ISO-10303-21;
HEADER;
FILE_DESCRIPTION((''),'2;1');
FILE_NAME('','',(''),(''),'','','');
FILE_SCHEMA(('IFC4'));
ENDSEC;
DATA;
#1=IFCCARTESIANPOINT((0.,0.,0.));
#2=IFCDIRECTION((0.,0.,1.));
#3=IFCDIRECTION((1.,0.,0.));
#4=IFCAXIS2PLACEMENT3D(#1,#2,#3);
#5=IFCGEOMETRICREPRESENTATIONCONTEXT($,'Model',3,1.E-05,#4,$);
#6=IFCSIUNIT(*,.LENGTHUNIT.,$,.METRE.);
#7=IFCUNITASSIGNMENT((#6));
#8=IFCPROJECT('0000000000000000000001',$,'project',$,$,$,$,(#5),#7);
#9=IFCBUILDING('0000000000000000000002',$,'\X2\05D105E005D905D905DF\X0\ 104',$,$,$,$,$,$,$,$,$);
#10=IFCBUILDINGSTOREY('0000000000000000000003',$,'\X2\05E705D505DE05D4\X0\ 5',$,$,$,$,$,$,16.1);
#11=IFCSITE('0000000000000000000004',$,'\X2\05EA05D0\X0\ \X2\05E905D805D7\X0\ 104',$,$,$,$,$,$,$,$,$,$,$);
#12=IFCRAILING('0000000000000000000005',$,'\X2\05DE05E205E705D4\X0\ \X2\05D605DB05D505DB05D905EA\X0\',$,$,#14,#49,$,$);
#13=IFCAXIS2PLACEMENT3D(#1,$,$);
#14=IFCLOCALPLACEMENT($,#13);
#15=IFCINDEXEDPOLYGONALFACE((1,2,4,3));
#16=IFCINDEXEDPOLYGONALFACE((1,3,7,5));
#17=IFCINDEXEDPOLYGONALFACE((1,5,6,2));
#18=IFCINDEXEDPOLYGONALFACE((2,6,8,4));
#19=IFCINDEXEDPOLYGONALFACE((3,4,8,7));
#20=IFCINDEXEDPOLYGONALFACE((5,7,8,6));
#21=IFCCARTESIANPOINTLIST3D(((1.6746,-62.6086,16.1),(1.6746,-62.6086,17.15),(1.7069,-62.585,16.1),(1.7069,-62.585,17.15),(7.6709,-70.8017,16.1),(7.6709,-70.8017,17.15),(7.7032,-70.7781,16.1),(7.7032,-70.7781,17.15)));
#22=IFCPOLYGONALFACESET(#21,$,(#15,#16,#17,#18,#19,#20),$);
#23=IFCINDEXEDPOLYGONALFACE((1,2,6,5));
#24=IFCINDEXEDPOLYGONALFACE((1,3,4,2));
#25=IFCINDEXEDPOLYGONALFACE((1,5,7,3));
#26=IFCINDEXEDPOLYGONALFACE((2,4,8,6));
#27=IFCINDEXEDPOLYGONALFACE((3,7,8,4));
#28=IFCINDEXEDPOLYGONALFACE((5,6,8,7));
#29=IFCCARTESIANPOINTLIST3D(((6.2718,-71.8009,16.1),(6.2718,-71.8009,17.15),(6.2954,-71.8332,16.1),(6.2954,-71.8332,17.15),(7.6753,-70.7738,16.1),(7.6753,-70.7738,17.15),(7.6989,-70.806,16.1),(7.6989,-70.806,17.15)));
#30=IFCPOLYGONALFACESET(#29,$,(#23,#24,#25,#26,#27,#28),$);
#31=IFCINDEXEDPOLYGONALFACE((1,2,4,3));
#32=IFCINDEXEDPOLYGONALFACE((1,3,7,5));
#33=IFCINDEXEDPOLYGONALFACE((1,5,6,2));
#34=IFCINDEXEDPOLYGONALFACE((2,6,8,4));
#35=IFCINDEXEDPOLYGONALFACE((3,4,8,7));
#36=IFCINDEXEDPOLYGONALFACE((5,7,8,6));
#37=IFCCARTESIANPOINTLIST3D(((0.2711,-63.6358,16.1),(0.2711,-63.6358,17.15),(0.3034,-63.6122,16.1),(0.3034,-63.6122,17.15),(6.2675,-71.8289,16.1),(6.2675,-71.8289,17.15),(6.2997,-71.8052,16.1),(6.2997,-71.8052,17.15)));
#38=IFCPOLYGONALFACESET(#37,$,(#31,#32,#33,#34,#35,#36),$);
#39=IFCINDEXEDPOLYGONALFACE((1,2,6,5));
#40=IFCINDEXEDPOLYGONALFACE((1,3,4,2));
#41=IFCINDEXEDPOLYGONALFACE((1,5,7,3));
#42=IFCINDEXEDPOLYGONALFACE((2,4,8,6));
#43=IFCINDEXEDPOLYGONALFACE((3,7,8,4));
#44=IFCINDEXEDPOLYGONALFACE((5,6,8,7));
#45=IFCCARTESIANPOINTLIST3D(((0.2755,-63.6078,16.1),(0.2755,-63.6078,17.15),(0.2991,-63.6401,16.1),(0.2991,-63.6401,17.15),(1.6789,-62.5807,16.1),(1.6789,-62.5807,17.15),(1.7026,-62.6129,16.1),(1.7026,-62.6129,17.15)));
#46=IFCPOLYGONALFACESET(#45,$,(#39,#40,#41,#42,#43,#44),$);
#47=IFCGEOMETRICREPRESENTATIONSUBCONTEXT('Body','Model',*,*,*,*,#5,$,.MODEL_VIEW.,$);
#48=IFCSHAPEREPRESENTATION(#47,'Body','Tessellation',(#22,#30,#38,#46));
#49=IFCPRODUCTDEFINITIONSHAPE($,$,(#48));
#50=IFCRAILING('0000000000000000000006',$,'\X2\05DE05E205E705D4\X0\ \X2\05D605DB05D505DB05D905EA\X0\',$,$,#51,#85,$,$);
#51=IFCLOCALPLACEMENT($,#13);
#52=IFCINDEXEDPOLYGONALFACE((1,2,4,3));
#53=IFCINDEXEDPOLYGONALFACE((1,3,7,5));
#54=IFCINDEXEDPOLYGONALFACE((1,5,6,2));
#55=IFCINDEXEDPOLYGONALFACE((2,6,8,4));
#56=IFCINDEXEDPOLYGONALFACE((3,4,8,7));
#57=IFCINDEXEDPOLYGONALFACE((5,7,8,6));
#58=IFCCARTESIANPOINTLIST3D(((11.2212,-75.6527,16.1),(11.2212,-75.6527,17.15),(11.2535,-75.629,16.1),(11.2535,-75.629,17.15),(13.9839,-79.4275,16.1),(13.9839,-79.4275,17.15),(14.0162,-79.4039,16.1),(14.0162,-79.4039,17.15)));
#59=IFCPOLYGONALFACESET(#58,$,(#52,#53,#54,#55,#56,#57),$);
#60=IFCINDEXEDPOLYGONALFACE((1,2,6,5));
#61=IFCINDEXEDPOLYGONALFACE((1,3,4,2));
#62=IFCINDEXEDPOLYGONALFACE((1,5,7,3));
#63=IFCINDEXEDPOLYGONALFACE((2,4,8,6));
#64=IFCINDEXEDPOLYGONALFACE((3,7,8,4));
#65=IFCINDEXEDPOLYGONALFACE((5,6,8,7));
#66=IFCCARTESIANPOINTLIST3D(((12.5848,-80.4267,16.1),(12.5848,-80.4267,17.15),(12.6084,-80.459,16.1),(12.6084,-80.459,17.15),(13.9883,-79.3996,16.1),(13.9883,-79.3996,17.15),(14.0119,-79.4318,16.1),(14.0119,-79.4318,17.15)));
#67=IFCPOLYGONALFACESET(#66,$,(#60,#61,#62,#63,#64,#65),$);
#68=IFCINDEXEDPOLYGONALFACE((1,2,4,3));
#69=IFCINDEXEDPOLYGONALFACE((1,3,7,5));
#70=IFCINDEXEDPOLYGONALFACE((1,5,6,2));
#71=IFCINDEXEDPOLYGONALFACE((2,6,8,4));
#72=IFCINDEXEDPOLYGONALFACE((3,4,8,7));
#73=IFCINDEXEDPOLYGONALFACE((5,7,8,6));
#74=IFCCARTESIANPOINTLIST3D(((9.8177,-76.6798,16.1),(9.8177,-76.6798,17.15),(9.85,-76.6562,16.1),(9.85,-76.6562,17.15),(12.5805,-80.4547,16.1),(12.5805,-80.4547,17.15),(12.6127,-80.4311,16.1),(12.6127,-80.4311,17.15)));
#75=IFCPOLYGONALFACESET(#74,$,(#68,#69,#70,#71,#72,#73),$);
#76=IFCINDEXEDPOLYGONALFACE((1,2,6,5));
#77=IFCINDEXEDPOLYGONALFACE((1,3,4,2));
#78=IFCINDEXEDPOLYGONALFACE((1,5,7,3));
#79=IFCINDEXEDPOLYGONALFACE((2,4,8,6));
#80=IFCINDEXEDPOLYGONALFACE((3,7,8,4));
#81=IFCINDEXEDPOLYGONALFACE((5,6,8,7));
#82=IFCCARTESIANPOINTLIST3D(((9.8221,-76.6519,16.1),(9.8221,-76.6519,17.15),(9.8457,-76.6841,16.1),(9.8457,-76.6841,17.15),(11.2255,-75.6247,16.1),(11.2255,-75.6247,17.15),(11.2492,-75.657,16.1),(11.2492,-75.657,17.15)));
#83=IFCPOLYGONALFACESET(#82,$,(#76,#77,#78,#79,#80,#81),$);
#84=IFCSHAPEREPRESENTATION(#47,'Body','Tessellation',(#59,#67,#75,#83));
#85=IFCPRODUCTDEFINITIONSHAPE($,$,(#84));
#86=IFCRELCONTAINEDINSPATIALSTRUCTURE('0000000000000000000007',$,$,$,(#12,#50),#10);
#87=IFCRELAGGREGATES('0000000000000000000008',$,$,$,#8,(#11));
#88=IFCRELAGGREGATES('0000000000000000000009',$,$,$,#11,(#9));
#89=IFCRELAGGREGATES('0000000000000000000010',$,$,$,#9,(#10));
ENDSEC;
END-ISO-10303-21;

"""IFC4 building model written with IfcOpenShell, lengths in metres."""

from ifc_helpers import new_model, si_unit, frame, origin_with_axes, context, subcontext, project, spatial, polyline, outline, extrude, element, save


model = new_model("IFC4")

# Units and contexts
model_context = context("Model", 3, precision=1e-05, world=origin_with_axes())
body_context = subcontext(model_context, "Body", "Model", "MODEL_VIEW")
ifc_project = project(units=[si_unit("LENGTHUNIT", "METRE")], contexts=[model_context])

# Site, building, storey
site = spatial("IfcSite", under=ifc_project, Name="תא שטח 104")
building = spatial("IfcBuilding", under=site, Name="בניין 104")
storey = spatial("IfcBuildingStorey", under=building, Name="קומה 5", Elevation=16.1)

# Railings
element("IfcRailing", 1, inside=storey, Name="מעקה זכוכית", context=body_context, shape_type="SweptSolid", body=[
    extrude(outline(polyline([(1.6746, -62.6086), (7.6709, -70.8017), (7.7032, -70.7781), (1.7069, -62.585), (1.6746, -62.6086)])), frame((0.0, 0.0, 16.1)), (0.0, 0.0, 1.0), 1.05),
    extrude(outline(polyline([(7.6753, -70.7738), (6.2718, -71.8009), (6.2954, -71.8332), (7.6989, -70.806), (7.6753, -70.7738)])), frame((0.0, 0.0, 16.1)), (0.0, 0.0, 1.0), 1.05),
    extrude(outline(polyline([(6.2997, -71.8052), (0.3034, -63.6122), (0.2711, -63.6358), (6.2675, -71.8289), (6.2997, -71.8052)])), frame((0.0, 0.0, 16.1)), (0.0, 0.0, 1.0), 1.05),
    extrude(outline(polyline([(0.2991, -63.6401), (1.7026, -62.6129), (1.6789, -62.5807), (0.2755, -63.6078), (0.2991, -63.6401)])), frame((0.0, 0.0, 16.1)), (0.0, 0.0, 1.0), 1.05),
])
element("IfcRailing", 2, inside=storey, Name="מעקה זכוכית", context=body_context, shape_type="SweptSolid", body=[
    extrude(outline(polyline([(11.2212, -75.6527), (13.9839, -79.4275), (14.0162, -79.4039), (11.2535, -75.629), (11.2212, -75.6527)])), frame((0.0, 0.0, 16.1)), (0.0, 0.0, 1.0), 1.05),
    extrude(outline(polyline([(13.9883, -79.3996), (12.5848, -80.4267), (12.6084, -80.459), (14.0119, -79.4318), (13.9883, -79.3996)])), frame((0.0, 0.0, 16.1)), (0.0, 0.0, 1.0), 1.05),
    extrude(outline(polyline([(12.6127, -80.4311), (9.85, -76.6562), (9.8177, -76.6798), (12.5805, -80.4547), (12.6127, -80.4311)])), frame((0.0, 0.0, 16.1)), (0.0, 0.0, 1.0), 1.05),
    extrude(outline(polyline([(9.8457, -76.6841), (11.2492, -75.657), (11.2255, -75.6247), (9.8221, -76.6519), (9.8457, -76.6841)])), frame((0.0, 0.0, 16.1)), (0.0, 0.0, 1.0), 1.05),
])

save(model, "model.ifc")
